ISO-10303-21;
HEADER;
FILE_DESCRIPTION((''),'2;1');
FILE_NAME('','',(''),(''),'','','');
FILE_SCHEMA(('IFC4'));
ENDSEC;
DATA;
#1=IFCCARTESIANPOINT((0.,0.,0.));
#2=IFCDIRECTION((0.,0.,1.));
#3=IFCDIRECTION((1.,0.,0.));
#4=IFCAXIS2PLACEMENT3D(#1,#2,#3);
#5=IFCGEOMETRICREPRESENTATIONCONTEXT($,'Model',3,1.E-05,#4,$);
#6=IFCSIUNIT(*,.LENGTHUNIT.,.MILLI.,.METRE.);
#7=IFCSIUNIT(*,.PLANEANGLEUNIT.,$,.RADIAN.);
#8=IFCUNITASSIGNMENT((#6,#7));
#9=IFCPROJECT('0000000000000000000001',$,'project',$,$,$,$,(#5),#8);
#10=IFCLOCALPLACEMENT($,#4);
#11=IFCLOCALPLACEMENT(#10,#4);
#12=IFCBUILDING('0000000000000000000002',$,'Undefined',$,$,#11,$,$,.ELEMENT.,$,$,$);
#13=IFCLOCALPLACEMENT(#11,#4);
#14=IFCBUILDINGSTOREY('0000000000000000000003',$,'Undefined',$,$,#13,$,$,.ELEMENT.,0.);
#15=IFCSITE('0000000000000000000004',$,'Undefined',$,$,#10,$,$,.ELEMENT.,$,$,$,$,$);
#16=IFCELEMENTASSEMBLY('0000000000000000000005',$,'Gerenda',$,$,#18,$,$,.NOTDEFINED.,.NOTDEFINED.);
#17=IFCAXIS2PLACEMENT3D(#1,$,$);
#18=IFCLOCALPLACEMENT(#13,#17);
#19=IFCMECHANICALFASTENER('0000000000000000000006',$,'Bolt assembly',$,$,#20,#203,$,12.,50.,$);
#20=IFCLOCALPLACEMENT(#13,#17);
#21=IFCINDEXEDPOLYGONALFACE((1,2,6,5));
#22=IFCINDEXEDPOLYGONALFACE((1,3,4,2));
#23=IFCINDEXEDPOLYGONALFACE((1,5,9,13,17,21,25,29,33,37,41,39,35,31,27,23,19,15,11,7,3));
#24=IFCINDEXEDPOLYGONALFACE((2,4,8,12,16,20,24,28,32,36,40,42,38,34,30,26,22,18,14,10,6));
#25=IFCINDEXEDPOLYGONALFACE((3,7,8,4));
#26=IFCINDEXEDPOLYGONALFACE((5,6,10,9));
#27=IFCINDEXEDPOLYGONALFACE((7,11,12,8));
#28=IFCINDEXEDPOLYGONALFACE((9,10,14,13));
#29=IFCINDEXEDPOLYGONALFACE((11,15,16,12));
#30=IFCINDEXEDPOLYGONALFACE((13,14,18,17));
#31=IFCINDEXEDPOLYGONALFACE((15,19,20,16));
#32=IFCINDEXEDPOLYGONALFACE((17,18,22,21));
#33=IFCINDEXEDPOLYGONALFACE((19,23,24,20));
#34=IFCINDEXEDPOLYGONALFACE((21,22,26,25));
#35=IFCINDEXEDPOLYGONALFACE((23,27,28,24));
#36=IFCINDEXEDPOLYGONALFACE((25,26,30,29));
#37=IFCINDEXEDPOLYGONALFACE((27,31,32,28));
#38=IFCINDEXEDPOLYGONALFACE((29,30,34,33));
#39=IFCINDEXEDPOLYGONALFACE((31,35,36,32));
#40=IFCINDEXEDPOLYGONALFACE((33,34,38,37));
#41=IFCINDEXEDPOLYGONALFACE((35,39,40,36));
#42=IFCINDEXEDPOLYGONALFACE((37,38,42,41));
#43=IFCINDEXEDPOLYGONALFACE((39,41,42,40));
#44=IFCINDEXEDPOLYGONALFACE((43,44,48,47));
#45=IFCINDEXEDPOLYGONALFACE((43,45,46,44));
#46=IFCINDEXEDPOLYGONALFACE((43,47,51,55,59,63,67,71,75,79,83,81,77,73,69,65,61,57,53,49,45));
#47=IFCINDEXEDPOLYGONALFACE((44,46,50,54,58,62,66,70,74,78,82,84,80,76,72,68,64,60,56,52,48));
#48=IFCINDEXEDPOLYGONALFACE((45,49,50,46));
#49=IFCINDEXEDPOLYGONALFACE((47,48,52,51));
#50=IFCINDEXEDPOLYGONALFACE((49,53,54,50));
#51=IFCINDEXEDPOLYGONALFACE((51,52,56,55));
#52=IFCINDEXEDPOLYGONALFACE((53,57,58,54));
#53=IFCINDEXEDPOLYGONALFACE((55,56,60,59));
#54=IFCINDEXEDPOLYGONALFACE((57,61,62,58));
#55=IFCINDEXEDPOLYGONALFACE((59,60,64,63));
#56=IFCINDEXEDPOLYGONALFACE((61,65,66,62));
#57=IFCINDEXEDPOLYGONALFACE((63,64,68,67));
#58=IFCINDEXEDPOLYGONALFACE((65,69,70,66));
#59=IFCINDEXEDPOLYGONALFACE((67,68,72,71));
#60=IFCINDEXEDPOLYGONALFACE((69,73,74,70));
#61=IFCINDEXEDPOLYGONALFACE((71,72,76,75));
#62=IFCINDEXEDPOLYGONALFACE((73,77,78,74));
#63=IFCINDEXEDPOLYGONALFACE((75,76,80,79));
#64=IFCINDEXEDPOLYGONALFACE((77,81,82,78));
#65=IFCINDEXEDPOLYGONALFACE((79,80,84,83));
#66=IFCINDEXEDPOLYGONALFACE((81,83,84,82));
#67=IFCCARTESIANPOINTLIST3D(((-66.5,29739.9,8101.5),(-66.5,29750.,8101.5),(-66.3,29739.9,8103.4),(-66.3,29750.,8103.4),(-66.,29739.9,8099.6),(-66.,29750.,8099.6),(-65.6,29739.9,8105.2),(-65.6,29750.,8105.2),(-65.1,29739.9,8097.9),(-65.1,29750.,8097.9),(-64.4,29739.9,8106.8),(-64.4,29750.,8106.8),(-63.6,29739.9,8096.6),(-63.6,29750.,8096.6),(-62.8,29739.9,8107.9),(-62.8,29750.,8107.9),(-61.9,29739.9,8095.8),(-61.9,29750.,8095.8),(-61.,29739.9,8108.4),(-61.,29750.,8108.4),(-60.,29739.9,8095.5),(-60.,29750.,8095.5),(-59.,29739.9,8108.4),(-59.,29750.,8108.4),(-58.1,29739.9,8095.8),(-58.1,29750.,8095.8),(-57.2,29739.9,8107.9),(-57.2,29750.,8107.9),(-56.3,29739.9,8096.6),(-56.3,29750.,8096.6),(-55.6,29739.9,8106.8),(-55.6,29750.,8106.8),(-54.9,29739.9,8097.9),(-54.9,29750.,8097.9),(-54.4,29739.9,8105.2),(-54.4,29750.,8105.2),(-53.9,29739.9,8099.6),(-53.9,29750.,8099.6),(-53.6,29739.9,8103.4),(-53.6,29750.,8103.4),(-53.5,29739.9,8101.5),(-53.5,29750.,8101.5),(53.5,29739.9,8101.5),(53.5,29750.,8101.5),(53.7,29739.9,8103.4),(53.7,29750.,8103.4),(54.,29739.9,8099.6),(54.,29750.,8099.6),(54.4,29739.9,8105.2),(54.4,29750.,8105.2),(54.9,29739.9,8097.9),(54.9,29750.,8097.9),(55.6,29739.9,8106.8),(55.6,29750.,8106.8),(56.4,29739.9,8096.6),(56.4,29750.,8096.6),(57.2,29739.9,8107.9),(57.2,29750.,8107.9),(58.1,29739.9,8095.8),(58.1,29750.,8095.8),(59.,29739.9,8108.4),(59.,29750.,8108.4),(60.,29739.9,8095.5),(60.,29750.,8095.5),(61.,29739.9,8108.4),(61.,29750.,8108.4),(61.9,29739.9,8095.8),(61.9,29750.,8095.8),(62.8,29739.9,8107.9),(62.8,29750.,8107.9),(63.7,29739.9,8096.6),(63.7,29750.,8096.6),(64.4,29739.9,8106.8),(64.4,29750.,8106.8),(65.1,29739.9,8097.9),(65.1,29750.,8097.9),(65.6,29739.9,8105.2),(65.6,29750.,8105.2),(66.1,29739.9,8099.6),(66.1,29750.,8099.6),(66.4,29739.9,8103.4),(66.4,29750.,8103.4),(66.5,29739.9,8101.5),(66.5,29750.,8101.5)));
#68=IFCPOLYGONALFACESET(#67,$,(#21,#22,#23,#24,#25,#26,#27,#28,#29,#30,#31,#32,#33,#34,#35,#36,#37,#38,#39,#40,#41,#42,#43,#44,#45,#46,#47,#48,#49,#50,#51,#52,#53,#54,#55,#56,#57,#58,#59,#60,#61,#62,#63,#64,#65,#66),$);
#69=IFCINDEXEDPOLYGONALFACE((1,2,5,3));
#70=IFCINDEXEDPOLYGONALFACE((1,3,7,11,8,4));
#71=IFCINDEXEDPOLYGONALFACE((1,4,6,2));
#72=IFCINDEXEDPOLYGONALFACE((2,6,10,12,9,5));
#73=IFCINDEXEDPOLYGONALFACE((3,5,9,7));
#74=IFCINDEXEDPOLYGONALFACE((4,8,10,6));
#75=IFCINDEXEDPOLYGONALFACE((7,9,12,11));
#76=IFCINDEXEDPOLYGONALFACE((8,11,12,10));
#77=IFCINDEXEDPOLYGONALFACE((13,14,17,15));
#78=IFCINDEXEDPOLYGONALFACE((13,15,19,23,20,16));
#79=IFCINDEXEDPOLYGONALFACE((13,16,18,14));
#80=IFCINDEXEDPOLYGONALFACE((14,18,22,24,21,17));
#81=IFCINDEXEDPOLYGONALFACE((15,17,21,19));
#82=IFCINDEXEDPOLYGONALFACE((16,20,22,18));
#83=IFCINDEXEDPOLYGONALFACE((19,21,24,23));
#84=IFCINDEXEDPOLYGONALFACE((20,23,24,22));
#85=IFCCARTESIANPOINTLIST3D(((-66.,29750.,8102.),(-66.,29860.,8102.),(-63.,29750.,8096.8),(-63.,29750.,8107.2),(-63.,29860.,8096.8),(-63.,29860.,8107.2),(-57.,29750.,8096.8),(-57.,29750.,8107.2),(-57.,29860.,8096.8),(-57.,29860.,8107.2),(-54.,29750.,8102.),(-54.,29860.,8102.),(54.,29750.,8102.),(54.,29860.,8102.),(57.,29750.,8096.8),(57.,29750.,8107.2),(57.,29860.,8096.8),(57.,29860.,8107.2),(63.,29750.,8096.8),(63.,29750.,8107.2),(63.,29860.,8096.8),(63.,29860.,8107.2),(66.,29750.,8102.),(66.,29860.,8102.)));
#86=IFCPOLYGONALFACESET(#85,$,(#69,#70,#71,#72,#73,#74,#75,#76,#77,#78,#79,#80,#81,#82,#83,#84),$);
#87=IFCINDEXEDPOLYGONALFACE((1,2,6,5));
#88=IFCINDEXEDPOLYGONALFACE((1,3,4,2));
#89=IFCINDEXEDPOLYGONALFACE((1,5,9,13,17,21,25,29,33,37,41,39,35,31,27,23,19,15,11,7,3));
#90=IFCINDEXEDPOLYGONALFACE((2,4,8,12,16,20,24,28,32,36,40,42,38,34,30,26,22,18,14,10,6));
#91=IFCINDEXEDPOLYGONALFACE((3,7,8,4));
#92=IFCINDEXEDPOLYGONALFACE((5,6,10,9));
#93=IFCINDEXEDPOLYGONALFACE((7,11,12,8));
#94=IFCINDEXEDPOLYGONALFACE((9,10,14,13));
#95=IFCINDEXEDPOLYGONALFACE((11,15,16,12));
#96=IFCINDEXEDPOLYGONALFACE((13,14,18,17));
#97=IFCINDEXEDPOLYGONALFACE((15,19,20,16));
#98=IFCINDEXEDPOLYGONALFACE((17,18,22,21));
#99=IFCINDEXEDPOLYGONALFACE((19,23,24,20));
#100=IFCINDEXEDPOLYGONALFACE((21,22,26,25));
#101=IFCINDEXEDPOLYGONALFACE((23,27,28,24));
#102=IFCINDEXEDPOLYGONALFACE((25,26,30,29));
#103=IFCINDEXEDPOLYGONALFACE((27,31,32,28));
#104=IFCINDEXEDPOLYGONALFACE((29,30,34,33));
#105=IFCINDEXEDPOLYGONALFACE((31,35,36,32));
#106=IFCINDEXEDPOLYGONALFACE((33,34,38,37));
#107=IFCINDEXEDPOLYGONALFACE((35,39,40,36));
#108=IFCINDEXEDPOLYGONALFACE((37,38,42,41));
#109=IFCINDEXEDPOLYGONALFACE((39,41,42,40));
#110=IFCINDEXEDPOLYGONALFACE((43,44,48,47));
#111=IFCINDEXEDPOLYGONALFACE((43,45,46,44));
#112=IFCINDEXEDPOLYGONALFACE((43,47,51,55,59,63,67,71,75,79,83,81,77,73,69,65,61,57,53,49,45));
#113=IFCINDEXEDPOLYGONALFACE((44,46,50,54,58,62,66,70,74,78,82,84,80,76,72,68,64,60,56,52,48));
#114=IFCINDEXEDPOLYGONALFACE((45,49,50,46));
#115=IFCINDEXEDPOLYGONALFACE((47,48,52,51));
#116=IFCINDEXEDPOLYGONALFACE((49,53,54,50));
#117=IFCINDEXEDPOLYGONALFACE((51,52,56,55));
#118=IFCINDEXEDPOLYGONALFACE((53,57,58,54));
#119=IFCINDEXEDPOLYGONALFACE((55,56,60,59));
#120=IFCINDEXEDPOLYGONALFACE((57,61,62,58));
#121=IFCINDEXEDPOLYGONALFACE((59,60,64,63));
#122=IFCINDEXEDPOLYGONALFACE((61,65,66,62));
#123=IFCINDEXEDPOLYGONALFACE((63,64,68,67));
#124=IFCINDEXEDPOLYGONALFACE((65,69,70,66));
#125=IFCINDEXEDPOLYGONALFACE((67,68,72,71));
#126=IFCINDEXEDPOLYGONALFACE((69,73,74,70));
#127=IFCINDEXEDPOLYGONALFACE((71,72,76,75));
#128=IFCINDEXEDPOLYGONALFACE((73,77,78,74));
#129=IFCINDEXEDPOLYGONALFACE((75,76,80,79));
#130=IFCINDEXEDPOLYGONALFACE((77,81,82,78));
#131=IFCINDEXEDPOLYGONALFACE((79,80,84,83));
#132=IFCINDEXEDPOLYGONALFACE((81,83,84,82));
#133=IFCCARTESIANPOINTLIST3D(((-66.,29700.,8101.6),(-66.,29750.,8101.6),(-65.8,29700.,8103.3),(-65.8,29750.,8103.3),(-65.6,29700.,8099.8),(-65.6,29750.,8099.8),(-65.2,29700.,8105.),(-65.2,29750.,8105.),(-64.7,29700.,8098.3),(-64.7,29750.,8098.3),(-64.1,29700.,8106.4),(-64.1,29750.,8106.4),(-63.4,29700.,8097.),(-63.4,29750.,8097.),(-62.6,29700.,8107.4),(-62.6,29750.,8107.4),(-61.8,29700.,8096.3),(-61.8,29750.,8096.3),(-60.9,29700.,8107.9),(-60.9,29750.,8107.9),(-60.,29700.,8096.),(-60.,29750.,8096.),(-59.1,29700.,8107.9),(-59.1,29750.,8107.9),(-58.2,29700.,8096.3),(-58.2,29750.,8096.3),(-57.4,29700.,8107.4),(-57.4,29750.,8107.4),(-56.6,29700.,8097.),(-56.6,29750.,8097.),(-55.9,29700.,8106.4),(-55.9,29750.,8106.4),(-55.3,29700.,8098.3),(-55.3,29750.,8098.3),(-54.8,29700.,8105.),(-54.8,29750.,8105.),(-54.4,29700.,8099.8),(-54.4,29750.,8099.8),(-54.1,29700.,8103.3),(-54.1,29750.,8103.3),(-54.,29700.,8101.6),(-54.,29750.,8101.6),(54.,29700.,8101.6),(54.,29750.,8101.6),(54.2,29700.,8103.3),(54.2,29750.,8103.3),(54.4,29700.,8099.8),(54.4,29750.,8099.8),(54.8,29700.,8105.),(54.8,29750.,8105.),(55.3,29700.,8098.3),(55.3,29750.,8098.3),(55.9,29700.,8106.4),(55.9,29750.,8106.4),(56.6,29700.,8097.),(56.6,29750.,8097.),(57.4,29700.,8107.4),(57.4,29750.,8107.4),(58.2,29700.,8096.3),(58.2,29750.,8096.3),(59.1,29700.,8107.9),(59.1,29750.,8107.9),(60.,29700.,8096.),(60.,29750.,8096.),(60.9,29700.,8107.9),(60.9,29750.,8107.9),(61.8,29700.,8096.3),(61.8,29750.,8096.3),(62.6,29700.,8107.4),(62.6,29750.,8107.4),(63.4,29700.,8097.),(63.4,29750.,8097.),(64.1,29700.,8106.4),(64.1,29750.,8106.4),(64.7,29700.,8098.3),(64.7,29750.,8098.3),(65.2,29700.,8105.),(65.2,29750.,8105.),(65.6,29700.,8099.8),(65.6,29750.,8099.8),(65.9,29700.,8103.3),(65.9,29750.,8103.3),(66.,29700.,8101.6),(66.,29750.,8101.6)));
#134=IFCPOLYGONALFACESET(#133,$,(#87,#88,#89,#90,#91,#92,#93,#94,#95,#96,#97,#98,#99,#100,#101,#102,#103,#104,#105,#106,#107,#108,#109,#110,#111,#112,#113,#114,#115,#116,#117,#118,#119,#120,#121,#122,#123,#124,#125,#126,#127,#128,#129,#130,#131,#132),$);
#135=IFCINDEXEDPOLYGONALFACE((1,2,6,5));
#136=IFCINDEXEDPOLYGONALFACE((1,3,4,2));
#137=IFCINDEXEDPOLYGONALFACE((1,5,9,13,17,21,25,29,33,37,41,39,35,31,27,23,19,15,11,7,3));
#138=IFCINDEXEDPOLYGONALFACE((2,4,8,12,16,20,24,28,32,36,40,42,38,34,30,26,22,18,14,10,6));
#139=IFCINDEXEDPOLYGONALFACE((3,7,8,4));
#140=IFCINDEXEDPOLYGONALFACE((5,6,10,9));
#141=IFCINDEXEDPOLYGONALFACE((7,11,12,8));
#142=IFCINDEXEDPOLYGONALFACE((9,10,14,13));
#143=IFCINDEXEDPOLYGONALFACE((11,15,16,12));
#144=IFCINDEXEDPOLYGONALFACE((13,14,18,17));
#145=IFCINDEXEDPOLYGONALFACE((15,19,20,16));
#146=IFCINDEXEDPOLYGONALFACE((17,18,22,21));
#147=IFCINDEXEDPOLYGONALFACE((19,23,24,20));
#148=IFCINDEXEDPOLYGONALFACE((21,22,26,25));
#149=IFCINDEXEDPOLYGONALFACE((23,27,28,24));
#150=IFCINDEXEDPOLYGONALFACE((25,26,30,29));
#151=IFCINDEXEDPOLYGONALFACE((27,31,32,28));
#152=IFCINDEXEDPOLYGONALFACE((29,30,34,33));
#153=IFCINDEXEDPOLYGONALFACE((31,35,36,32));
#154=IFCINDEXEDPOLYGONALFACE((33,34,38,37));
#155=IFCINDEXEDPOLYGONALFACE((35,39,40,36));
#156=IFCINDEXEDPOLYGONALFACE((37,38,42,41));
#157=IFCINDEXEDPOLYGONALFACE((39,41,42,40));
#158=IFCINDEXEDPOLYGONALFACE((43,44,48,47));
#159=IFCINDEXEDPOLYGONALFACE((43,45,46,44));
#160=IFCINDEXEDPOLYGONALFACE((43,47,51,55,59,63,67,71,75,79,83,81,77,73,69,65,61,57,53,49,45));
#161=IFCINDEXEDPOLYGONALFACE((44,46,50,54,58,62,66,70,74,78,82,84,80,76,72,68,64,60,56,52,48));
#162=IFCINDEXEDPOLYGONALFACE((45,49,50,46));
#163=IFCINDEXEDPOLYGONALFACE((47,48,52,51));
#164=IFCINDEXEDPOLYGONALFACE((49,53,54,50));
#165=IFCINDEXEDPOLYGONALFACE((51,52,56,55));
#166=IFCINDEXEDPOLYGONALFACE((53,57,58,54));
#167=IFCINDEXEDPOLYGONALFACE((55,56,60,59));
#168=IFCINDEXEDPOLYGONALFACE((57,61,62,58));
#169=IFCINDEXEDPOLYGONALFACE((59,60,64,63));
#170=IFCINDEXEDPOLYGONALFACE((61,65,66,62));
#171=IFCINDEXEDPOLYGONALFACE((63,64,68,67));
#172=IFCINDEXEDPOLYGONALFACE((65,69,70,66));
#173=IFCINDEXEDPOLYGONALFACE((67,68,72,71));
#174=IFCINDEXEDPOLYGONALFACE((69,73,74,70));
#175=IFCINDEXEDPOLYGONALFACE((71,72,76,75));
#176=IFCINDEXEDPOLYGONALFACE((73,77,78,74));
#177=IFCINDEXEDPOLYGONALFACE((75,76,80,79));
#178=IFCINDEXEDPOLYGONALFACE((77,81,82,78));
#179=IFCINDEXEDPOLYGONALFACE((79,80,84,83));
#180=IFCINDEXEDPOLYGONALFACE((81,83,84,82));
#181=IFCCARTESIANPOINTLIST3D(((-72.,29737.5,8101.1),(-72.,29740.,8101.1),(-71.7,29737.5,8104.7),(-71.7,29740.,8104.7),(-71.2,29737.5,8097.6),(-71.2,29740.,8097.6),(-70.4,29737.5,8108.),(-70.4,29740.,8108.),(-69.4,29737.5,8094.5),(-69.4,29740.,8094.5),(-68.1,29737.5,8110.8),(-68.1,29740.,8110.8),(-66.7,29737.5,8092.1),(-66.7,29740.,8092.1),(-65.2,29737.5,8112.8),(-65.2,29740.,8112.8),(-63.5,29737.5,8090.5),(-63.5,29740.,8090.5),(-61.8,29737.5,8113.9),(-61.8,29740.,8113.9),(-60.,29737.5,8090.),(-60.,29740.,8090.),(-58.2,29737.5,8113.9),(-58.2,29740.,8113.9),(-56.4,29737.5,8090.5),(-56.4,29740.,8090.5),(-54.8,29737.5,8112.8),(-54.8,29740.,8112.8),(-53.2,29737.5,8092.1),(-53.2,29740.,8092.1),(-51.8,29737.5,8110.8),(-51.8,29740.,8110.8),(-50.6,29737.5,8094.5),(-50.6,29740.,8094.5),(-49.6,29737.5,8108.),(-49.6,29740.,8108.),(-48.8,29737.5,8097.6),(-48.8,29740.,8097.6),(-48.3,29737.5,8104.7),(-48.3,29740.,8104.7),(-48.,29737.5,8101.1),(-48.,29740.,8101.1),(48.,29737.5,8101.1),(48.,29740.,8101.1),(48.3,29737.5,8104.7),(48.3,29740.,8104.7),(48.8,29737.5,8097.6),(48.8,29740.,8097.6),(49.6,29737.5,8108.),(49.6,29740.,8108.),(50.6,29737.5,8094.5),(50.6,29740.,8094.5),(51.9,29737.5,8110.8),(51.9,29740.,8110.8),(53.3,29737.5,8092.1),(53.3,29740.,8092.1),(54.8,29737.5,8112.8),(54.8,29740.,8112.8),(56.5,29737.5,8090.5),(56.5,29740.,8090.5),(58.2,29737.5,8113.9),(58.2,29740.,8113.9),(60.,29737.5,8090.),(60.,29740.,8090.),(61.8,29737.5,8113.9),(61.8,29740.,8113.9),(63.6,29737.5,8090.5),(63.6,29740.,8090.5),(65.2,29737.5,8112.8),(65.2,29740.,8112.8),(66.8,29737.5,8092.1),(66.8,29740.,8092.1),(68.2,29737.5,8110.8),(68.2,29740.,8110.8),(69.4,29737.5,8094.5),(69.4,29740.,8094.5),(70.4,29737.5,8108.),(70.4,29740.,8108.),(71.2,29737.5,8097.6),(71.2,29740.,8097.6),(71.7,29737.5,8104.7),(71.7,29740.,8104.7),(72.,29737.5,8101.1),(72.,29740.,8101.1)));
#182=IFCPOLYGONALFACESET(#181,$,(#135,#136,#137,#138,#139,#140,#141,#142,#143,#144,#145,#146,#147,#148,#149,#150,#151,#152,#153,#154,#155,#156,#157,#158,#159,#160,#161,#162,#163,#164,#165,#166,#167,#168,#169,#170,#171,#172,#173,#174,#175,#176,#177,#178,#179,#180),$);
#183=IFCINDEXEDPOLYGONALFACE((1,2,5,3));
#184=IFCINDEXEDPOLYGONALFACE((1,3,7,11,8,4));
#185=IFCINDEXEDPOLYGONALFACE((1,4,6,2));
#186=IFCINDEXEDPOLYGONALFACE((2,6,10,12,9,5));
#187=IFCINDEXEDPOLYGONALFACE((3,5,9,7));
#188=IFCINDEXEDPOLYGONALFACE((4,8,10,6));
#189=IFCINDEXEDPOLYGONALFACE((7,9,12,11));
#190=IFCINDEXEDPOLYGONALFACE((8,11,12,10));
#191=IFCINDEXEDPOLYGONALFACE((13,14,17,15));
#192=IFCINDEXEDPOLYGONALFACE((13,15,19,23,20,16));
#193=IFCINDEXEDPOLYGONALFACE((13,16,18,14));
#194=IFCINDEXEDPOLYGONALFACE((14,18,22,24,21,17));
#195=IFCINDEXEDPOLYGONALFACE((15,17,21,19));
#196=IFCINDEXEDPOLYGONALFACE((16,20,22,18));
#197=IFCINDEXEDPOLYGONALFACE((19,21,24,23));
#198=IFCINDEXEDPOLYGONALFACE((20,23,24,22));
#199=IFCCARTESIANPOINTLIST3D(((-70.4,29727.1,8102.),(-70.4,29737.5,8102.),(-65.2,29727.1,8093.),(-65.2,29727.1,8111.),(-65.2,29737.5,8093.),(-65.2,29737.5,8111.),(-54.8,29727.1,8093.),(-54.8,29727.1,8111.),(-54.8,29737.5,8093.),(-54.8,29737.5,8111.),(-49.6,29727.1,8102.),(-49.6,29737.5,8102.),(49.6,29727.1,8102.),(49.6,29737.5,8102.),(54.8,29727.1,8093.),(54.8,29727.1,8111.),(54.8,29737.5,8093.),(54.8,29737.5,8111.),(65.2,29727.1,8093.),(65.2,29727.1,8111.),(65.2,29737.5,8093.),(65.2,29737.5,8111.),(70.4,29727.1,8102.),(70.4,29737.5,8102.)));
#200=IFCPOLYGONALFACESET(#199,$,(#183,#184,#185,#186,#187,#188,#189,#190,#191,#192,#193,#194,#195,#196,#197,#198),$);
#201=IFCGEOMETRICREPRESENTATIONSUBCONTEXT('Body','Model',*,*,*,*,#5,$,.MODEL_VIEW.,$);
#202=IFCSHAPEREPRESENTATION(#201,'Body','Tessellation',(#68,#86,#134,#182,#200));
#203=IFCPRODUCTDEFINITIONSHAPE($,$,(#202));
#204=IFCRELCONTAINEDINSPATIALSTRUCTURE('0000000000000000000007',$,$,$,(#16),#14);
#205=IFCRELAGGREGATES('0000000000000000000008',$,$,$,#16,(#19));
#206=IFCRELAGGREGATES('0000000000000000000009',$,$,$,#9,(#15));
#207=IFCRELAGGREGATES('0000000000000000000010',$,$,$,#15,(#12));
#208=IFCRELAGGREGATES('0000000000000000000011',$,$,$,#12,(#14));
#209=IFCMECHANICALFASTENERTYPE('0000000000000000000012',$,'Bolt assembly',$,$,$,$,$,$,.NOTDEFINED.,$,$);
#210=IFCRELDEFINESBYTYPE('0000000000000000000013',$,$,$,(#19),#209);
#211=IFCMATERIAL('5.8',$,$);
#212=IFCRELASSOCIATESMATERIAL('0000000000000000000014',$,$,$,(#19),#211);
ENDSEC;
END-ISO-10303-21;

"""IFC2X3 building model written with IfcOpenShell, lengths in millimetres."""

from ifc_helpers import new_model, si_unit, frame, origin_with_axes, origin_2d_with_axis, place, context, subcontext, project, spatial, polyline, circle, outline, extrude, source, transform, mapped, material, type_object, element, aggregate, save


model = new_model("IFC2X3")

# Units and contexts
model_context = context("Model", 3, precision=1e-05, world=origin_with_axes())
body_context = subcontext(model_context, "Body", "Model", "MODEL_VIEW")
ifc_project = project(units=[si_unit("LENGTHUNIT", "METRE", prefix="MILLI"), si_unit("PLANEANGLEUNIT", "RADIAN")], contexts=[model_context])

# Site, building, storey
site_placement = place(None, origin_with_axes())
site = spatial("IfcSite", under=ifc_project, at=site_placement, Name="Undefined", CompositionType="ELEMENT")
building_placement = place(site_placement, origin_with_axes())
building = spatial("IfcBuilding", under=site, at=building_placement, Name="Undefined", CompositionType="ELEMENT")
storey_placement = place(building_placement, origin_with_axes())
storey = spatial("IfcBuildingStorey", under=building, at=storey_placement, Name="Undefined", CompositionType="ELEMENT", Elevation=0.0)

# Element assembly
assembly_1_placement = place(storey_placement, origin_with_axes())
assembly_1 = element("IfcElementAssembly", 1, at=assembly_1_placement, inside=storey, Name="Gerenda", AssemblyPlace="NOTDEFINED", PredefinedType="NOTDEFINED")

# Shared definitions
mechanical_fastener_type = type_object("IfcMechanicalFastenerType", Name="Bolt assembly")

# Mechanical fastener
ifc_material_1 = material(Name="5.8")
shared_shape_1 = source(origin_with_axes(), body_context, "Body", "SweptSolid", [
    extrude(circle(Radius=6.5, at=origin_2d_with_axis()), frame((0.0, -10.0, 0.0), z_axis=(0.0, 1.0, 0.0), x_axis=(1.0, 0.0, 0.0)), (0.0, 0.0, 1.0), 10.1),
    extrude(outline(polyline([(5.2, -3.0), (5.2, 3.0), (0.0, 6.0), (-5.2, 3.0), (-5.2, -3.0), (0.0, -6.0), (5.2, -3.0)])), frame((0.0, -120.0, 0.0), z_axis=(0.0, 1.0, 0.0), x_axis=(1.0, 0.0, 0.0)), (0.0, 0.0, 1.0), 110.0),
    extrude(circle(Radius=6.0, at=origin_2d_with_axis()), frame((0.0, -10.0, 0.0), z_axis=(0.0, 1.0, 0.0), x_axis=(1.0, 0.0, 0.0)), (0.0, 0.0, 1.0), 50.0),
    extrude(circle(Radius=12.0, at=origin_2d_with_axis()), frame((0.0, 0.0, 0.0), z_axis=(0.0, 1.0, 0.0), x_axis=(1.0, 0.0, 0.0)), (0.0, 0.0, 1.0), 2.5),
    extrude(outline(polyline([(9.0, -5.2), (9.0, 5.2), (0.0, 10.4), (-9.0, 5.2), (-9.0, -5.2), (0.0, -10.4), (9.0, -5.2)])), frame((0.0, 2.5, 0.0), z_axis=(0.0, 1.0, 0.0), x_axis=(1.0, 0.0, 0.0)), (0.0, 0.0, 1.0), 10.4),
])
mechanical_fastener_1_placement = place(assembly_1_placement, frame((0.0, 29740.0, 8150.0), z_axis=(-1.0, 0.000003, 0.0), x_axis=(0.0, 0.0, -1.0)))
mechanical_fastener_1 = element("IfcMechanicalFastener", 2, at=mechanical_fastener_1_placement, type_object=mechanical_fastener_type, material=ifc_material_1, Name="Bolt assembly", NominalDiameter=12.0, NominalLength=50.0, context=body_context, shape_type="MappedRepresentation", body=[
    mapped(shared_shape_1, transform((48.0, 0.0, -60.0))),
    mapped(shared_shape_1, transform((48.0, 0.0, 60.0))),
])
aggregate(assembly_1, [mechanical_fastener_1])

save(model, "model.ifc")
